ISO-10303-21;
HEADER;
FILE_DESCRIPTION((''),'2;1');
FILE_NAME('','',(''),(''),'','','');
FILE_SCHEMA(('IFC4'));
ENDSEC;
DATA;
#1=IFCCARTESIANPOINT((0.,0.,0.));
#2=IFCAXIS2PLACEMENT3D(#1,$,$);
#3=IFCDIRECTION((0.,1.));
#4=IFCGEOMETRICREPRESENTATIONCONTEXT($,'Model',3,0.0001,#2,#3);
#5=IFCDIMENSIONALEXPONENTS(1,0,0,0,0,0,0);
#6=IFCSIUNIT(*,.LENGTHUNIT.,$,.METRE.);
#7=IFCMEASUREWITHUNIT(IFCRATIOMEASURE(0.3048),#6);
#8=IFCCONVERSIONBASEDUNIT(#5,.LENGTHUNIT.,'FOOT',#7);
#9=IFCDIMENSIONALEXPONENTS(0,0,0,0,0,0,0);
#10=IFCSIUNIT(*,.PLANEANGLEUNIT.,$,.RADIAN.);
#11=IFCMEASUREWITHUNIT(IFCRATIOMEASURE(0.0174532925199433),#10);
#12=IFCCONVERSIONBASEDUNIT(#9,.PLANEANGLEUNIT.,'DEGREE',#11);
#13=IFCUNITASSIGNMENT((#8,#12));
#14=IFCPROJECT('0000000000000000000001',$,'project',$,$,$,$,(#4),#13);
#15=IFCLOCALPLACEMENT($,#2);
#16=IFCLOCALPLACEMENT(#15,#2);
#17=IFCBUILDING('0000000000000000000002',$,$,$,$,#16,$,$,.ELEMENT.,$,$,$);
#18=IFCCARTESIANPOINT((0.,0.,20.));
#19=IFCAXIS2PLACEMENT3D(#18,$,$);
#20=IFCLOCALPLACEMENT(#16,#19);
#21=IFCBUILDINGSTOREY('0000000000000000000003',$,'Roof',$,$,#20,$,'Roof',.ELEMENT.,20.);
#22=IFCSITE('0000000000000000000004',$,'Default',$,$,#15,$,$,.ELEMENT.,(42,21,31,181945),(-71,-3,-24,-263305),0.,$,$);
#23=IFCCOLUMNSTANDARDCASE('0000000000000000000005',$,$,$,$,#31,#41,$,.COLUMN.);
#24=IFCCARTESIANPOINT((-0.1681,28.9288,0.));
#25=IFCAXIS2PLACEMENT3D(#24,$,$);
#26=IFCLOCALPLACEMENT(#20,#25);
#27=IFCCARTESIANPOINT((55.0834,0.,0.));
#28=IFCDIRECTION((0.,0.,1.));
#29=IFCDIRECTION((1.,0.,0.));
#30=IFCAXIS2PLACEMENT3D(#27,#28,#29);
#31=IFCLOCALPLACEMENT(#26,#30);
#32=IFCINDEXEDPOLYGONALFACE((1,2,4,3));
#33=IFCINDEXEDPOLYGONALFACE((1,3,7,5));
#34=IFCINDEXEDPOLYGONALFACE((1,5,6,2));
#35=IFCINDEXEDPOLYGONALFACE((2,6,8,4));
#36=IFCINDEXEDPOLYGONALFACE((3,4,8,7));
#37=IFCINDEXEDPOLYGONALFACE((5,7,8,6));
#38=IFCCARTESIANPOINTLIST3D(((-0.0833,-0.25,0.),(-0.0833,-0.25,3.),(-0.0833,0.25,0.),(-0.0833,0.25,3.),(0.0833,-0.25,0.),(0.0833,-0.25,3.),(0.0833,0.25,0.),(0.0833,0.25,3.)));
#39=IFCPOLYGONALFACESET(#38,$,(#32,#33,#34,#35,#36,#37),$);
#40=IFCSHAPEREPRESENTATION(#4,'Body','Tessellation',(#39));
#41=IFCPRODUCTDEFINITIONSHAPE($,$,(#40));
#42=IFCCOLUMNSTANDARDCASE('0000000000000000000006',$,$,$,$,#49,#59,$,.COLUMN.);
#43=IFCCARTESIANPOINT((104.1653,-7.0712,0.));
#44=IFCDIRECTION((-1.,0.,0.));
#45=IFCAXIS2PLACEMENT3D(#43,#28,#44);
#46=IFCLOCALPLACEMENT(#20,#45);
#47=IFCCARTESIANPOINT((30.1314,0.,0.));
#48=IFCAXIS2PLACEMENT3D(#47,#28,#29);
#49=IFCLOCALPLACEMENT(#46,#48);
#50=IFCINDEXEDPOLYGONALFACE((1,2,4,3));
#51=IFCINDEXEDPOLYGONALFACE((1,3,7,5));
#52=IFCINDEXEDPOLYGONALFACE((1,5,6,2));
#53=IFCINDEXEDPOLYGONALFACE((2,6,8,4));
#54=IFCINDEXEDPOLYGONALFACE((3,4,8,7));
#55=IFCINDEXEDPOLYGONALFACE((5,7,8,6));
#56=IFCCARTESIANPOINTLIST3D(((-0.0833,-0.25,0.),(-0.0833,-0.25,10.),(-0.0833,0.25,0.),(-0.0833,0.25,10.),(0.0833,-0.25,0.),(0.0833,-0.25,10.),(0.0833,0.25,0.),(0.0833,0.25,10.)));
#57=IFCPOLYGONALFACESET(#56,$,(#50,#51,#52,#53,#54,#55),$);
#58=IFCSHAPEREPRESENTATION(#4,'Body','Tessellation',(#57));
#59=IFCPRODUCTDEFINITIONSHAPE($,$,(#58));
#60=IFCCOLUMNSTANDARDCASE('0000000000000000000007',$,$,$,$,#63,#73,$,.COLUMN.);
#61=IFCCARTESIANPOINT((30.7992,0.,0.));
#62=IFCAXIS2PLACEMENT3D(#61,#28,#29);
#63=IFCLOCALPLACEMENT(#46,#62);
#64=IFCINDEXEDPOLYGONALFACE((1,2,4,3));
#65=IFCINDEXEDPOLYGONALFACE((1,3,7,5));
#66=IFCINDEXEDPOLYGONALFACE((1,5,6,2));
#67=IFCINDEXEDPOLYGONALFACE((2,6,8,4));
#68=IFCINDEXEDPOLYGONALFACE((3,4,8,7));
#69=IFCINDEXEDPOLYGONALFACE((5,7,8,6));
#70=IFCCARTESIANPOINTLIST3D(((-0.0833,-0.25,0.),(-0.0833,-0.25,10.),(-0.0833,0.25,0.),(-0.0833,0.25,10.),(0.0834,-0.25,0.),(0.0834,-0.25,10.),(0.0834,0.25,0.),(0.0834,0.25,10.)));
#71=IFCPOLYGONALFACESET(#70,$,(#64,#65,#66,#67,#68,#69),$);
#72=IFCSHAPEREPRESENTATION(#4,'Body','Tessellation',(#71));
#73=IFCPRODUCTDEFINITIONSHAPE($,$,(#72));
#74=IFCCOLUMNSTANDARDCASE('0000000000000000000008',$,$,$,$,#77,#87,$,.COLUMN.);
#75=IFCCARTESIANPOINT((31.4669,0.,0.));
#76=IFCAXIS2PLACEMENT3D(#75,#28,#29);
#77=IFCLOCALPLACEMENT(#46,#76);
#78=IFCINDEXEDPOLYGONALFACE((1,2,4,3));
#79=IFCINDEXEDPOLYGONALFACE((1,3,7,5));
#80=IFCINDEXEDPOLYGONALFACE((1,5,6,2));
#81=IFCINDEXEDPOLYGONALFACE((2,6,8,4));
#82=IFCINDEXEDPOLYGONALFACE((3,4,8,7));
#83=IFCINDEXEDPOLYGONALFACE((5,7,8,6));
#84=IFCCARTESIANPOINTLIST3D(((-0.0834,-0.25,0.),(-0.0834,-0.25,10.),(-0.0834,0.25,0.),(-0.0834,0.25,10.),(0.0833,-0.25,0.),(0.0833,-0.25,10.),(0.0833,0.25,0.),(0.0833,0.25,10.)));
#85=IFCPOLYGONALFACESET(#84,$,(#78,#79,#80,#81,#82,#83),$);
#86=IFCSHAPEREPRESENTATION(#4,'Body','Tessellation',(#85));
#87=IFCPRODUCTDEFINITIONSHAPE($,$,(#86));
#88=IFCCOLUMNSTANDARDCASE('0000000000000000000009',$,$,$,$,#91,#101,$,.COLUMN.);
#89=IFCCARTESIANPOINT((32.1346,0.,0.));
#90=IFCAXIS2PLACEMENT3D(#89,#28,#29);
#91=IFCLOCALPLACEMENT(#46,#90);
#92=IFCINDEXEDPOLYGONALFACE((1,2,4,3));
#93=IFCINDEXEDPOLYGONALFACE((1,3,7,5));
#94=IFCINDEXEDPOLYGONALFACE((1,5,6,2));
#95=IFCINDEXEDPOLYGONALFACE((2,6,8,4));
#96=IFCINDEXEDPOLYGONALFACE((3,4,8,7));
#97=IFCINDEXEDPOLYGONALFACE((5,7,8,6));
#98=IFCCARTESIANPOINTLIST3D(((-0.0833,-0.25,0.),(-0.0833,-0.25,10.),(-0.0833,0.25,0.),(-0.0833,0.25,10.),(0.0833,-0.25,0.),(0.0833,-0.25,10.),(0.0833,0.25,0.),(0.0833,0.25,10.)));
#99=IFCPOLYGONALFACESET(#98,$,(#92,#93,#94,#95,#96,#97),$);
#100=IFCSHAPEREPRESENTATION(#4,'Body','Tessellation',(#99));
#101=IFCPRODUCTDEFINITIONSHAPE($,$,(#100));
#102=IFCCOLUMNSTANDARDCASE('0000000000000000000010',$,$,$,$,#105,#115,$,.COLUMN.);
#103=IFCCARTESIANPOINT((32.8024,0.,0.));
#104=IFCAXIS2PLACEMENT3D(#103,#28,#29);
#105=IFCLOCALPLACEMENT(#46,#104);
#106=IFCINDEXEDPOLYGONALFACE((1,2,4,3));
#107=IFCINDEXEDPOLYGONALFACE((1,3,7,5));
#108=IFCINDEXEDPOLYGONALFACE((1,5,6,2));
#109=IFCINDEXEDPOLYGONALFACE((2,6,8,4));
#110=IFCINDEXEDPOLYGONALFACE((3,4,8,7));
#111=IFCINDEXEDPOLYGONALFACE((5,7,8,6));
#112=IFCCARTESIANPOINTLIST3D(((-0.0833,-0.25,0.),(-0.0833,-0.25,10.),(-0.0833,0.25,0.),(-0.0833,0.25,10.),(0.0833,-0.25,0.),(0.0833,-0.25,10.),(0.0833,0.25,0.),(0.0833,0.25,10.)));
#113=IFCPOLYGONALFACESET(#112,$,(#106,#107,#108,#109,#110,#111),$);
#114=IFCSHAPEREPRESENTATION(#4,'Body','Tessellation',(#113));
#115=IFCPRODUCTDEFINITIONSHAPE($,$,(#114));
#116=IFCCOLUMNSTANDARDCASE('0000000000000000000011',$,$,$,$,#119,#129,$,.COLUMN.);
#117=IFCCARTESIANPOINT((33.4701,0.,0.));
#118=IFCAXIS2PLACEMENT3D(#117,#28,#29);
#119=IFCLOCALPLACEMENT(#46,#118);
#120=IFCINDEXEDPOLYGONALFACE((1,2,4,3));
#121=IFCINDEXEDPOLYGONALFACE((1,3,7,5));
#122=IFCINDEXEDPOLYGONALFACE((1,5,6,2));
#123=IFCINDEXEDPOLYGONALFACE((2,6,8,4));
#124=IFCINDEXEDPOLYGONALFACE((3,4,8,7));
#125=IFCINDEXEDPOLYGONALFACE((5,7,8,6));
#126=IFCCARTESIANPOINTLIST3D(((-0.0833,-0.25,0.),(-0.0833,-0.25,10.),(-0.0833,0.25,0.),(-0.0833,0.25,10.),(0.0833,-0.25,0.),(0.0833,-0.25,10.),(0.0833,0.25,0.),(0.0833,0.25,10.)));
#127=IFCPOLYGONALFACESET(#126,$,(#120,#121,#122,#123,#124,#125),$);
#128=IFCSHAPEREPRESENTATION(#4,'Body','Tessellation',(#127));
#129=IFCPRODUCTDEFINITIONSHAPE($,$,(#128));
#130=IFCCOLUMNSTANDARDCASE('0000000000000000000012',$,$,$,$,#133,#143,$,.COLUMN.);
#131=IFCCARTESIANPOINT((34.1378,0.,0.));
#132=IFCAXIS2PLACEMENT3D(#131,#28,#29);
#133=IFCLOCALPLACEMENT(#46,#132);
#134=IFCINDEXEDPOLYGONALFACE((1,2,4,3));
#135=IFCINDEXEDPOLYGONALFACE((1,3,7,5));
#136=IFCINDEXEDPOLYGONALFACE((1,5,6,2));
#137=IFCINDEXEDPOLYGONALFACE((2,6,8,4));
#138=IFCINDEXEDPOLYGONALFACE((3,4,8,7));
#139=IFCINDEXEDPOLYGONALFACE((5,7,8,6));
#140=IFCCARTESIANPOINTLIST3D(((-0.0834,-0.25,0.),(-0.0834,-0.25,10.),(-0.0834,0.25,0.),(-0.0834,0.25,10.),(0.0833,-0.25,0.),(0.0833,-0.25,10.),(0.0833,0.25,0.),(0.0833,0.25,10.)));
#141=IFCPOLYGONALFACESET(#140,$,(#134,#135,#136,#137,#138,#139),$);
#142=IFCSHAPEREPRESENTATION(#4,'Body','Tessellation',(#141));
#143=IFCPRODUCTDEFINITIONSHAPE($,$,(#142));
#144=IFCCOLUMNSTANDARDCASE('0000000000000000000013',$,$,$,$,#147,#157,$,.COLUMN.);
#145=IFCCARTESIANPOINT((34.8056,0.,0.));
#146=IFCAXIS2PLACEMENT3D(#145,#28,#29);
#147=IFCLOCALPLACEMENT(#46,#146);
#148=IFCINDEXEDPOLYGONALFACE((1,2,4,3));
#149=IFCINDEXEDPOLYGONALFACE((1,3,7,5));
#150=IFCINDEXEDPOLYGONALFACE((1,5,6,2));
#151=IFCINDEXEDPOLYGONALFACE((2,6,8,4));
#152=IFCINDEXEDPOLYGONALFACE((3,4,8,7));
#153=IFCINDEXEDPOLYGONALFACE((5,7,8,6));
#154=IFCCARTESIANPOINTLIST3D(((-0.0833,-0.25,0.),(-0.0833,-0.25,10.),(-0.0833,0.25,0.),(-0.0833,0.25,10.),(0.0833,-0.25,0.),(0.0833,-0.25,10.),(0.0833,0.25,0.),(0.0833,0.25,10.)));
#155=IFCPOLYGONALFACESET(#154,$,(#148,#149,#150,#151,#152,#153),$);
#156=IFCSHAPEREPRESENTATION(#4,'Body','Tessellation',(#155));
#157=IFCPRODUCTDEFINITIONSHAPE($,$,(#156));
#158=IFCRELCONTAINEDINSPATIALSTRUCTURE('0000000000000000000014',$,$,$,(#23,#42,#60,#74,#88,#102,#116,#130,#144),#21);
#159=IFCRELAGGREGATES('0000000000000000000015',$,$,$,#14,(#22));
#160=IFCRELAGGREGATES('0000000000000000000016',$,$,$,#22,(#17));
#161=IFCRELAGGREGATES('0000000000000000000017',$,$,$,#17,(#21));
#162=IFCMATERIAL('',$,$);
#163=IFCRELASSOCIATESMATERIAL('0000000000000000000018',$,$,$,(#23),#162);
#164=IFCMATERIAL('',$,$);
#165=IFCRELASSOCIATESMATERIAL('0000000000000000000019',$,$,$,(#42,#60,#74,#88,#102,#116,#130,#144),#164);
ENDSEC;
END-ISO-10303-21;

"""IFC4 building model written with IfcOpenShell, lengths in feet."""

from ifc_helpers import new_model, entity, si_unit, converted_unit, direction, frame, origin, place, context, project, spatial, rectangle, extrude, material, element, save


model = new_model("IFC4")

# Units and contexts
model_context = context("Model", 3, precision=0.0001, world=origin(), true_north=direction((0.0, 1.0)))
ifc_project = project(units=[converted_unit("LENGTHUNIT", "FOOT", entity("IfcRatioMeasure", 0.3048), si_unit("LENGTHUNIT", "METRE"), dimensions=[1, 0, 0, 0, 0, 0, 0]), converted_unit("PLANEANGLEUNIT", "DEGREE", entity("IfcRatioMeasure", 0.0174532925199433), si_unit("PLANEANGLEUNIT", "RADIAN"), dimensions=[0, 0, 0, 0, 0, 0, 0])], contexts=[model_context])

# Site, building, storey
site_placement = place(None, origin())
site = spatial("IfcSite", under=ifc_project, at=site_placement, Name="Default", CompositionType="ELEMENT", RefLatitude=(42, 21, 31, 181945), RefLongitude=(-71, -3, -24, -263305), RefElevation=0.0)
building_placement = place(site_placement, origin())
building = spatial("IfcBuilding", under=site, at=building_placement, CompositionType="ELEMENT")
storey_placement = place(building_placement, frame((0.0, 0.0, 20.0)))
storey = spatial("IfcBuildingStorey", under=building, at=storey_placement, Name="Roof", LongName="Roof", CompositionType="ELEMENT", Elevation=20.0)

# Columns
placement_1 = place(storey_placement, frame((-0.1681, 28.9288, 0.0)))
ifc_material_1 = material(Name="")
for number, where, z_axis, x_axis in (
    (1, (55.0834, 0.0, 0.0), (0.0, 0.0, 1.0), (1.0, 0.0, 0.0)),
):
    element("IfcColumnStandardCase", number, at=place(placement_1, frame(where, z_axis=z_axis, x_axis=x_axis)), inside=storey, material=ifc_material_1, PredefinedType="COLUMN", context=model_context, shape_type="SweptSolid", body=[
        extrude(rectangle(XDim=0.1667, YDim=0.5), origin(), (0.0, 0.0, 1.0), 3.0),
    ])
ifc_material_2 = material(Name="")
placement_2 = place(storey_placement, frame((104.1653, -7.0712, 0.0), z_axis=(0.0, 0.0, 1.0), x_axis=(-1.0, 0.0, 0.0)))
for number, where, z_axis, x_axis in (
    (2, (30.1314, 0.0, 0.0), (0.0, 0.0, 1.0), (1.0, 0.0, 0.0)),
    (3, (30.7992, 0.0, 0.0), (0.0, 0.0, 1.0), (1.0, 0.0, 0.0)),
    (4, (31.4669, 0.0, 0.0), (0.0, 0.0, 1.0), (1.0, 0.0, 0.0)),
    (5, (32.1346, 0.0, 0.0), (0.0, 0.0, 1.0), (1.0, 0.0, 0.0)),
    (6, (32.8024, 0.0, 0.0), (0.0, 0.0, 1.0), (1.0, 0.0, 0.0)),
    (7, (33.4701, 0.0, 0.0), (0.0, 0.0, 1.0), (1.0, 0.0, 0.0)),
    (8, (34.1378, 0.0, 0.0), (0.0, 0.0, 1.0), (1.0, 0.0, 0.0)),
    (9, (34.8056, 0.0, 0.0), (0.0, 0.0, 1.0), (1.0, 0.0, 0.0)),
):
    element("IfcColumnStandardCase", number, at=place(placement_2, frame(where, z_axis=z_axis, x_axis=x_axis)), inside=storey, material=ifc_material_2, PredefinedType="COLUMN", context=model_context, shape_type="SweptSolid", body=[
        extrude(rectangle(XDim=0.1667, YDim=0.5), origin(), (0.0, 0.0, 1.0), 10.0),
    ])

save(model, "model.ifc")
